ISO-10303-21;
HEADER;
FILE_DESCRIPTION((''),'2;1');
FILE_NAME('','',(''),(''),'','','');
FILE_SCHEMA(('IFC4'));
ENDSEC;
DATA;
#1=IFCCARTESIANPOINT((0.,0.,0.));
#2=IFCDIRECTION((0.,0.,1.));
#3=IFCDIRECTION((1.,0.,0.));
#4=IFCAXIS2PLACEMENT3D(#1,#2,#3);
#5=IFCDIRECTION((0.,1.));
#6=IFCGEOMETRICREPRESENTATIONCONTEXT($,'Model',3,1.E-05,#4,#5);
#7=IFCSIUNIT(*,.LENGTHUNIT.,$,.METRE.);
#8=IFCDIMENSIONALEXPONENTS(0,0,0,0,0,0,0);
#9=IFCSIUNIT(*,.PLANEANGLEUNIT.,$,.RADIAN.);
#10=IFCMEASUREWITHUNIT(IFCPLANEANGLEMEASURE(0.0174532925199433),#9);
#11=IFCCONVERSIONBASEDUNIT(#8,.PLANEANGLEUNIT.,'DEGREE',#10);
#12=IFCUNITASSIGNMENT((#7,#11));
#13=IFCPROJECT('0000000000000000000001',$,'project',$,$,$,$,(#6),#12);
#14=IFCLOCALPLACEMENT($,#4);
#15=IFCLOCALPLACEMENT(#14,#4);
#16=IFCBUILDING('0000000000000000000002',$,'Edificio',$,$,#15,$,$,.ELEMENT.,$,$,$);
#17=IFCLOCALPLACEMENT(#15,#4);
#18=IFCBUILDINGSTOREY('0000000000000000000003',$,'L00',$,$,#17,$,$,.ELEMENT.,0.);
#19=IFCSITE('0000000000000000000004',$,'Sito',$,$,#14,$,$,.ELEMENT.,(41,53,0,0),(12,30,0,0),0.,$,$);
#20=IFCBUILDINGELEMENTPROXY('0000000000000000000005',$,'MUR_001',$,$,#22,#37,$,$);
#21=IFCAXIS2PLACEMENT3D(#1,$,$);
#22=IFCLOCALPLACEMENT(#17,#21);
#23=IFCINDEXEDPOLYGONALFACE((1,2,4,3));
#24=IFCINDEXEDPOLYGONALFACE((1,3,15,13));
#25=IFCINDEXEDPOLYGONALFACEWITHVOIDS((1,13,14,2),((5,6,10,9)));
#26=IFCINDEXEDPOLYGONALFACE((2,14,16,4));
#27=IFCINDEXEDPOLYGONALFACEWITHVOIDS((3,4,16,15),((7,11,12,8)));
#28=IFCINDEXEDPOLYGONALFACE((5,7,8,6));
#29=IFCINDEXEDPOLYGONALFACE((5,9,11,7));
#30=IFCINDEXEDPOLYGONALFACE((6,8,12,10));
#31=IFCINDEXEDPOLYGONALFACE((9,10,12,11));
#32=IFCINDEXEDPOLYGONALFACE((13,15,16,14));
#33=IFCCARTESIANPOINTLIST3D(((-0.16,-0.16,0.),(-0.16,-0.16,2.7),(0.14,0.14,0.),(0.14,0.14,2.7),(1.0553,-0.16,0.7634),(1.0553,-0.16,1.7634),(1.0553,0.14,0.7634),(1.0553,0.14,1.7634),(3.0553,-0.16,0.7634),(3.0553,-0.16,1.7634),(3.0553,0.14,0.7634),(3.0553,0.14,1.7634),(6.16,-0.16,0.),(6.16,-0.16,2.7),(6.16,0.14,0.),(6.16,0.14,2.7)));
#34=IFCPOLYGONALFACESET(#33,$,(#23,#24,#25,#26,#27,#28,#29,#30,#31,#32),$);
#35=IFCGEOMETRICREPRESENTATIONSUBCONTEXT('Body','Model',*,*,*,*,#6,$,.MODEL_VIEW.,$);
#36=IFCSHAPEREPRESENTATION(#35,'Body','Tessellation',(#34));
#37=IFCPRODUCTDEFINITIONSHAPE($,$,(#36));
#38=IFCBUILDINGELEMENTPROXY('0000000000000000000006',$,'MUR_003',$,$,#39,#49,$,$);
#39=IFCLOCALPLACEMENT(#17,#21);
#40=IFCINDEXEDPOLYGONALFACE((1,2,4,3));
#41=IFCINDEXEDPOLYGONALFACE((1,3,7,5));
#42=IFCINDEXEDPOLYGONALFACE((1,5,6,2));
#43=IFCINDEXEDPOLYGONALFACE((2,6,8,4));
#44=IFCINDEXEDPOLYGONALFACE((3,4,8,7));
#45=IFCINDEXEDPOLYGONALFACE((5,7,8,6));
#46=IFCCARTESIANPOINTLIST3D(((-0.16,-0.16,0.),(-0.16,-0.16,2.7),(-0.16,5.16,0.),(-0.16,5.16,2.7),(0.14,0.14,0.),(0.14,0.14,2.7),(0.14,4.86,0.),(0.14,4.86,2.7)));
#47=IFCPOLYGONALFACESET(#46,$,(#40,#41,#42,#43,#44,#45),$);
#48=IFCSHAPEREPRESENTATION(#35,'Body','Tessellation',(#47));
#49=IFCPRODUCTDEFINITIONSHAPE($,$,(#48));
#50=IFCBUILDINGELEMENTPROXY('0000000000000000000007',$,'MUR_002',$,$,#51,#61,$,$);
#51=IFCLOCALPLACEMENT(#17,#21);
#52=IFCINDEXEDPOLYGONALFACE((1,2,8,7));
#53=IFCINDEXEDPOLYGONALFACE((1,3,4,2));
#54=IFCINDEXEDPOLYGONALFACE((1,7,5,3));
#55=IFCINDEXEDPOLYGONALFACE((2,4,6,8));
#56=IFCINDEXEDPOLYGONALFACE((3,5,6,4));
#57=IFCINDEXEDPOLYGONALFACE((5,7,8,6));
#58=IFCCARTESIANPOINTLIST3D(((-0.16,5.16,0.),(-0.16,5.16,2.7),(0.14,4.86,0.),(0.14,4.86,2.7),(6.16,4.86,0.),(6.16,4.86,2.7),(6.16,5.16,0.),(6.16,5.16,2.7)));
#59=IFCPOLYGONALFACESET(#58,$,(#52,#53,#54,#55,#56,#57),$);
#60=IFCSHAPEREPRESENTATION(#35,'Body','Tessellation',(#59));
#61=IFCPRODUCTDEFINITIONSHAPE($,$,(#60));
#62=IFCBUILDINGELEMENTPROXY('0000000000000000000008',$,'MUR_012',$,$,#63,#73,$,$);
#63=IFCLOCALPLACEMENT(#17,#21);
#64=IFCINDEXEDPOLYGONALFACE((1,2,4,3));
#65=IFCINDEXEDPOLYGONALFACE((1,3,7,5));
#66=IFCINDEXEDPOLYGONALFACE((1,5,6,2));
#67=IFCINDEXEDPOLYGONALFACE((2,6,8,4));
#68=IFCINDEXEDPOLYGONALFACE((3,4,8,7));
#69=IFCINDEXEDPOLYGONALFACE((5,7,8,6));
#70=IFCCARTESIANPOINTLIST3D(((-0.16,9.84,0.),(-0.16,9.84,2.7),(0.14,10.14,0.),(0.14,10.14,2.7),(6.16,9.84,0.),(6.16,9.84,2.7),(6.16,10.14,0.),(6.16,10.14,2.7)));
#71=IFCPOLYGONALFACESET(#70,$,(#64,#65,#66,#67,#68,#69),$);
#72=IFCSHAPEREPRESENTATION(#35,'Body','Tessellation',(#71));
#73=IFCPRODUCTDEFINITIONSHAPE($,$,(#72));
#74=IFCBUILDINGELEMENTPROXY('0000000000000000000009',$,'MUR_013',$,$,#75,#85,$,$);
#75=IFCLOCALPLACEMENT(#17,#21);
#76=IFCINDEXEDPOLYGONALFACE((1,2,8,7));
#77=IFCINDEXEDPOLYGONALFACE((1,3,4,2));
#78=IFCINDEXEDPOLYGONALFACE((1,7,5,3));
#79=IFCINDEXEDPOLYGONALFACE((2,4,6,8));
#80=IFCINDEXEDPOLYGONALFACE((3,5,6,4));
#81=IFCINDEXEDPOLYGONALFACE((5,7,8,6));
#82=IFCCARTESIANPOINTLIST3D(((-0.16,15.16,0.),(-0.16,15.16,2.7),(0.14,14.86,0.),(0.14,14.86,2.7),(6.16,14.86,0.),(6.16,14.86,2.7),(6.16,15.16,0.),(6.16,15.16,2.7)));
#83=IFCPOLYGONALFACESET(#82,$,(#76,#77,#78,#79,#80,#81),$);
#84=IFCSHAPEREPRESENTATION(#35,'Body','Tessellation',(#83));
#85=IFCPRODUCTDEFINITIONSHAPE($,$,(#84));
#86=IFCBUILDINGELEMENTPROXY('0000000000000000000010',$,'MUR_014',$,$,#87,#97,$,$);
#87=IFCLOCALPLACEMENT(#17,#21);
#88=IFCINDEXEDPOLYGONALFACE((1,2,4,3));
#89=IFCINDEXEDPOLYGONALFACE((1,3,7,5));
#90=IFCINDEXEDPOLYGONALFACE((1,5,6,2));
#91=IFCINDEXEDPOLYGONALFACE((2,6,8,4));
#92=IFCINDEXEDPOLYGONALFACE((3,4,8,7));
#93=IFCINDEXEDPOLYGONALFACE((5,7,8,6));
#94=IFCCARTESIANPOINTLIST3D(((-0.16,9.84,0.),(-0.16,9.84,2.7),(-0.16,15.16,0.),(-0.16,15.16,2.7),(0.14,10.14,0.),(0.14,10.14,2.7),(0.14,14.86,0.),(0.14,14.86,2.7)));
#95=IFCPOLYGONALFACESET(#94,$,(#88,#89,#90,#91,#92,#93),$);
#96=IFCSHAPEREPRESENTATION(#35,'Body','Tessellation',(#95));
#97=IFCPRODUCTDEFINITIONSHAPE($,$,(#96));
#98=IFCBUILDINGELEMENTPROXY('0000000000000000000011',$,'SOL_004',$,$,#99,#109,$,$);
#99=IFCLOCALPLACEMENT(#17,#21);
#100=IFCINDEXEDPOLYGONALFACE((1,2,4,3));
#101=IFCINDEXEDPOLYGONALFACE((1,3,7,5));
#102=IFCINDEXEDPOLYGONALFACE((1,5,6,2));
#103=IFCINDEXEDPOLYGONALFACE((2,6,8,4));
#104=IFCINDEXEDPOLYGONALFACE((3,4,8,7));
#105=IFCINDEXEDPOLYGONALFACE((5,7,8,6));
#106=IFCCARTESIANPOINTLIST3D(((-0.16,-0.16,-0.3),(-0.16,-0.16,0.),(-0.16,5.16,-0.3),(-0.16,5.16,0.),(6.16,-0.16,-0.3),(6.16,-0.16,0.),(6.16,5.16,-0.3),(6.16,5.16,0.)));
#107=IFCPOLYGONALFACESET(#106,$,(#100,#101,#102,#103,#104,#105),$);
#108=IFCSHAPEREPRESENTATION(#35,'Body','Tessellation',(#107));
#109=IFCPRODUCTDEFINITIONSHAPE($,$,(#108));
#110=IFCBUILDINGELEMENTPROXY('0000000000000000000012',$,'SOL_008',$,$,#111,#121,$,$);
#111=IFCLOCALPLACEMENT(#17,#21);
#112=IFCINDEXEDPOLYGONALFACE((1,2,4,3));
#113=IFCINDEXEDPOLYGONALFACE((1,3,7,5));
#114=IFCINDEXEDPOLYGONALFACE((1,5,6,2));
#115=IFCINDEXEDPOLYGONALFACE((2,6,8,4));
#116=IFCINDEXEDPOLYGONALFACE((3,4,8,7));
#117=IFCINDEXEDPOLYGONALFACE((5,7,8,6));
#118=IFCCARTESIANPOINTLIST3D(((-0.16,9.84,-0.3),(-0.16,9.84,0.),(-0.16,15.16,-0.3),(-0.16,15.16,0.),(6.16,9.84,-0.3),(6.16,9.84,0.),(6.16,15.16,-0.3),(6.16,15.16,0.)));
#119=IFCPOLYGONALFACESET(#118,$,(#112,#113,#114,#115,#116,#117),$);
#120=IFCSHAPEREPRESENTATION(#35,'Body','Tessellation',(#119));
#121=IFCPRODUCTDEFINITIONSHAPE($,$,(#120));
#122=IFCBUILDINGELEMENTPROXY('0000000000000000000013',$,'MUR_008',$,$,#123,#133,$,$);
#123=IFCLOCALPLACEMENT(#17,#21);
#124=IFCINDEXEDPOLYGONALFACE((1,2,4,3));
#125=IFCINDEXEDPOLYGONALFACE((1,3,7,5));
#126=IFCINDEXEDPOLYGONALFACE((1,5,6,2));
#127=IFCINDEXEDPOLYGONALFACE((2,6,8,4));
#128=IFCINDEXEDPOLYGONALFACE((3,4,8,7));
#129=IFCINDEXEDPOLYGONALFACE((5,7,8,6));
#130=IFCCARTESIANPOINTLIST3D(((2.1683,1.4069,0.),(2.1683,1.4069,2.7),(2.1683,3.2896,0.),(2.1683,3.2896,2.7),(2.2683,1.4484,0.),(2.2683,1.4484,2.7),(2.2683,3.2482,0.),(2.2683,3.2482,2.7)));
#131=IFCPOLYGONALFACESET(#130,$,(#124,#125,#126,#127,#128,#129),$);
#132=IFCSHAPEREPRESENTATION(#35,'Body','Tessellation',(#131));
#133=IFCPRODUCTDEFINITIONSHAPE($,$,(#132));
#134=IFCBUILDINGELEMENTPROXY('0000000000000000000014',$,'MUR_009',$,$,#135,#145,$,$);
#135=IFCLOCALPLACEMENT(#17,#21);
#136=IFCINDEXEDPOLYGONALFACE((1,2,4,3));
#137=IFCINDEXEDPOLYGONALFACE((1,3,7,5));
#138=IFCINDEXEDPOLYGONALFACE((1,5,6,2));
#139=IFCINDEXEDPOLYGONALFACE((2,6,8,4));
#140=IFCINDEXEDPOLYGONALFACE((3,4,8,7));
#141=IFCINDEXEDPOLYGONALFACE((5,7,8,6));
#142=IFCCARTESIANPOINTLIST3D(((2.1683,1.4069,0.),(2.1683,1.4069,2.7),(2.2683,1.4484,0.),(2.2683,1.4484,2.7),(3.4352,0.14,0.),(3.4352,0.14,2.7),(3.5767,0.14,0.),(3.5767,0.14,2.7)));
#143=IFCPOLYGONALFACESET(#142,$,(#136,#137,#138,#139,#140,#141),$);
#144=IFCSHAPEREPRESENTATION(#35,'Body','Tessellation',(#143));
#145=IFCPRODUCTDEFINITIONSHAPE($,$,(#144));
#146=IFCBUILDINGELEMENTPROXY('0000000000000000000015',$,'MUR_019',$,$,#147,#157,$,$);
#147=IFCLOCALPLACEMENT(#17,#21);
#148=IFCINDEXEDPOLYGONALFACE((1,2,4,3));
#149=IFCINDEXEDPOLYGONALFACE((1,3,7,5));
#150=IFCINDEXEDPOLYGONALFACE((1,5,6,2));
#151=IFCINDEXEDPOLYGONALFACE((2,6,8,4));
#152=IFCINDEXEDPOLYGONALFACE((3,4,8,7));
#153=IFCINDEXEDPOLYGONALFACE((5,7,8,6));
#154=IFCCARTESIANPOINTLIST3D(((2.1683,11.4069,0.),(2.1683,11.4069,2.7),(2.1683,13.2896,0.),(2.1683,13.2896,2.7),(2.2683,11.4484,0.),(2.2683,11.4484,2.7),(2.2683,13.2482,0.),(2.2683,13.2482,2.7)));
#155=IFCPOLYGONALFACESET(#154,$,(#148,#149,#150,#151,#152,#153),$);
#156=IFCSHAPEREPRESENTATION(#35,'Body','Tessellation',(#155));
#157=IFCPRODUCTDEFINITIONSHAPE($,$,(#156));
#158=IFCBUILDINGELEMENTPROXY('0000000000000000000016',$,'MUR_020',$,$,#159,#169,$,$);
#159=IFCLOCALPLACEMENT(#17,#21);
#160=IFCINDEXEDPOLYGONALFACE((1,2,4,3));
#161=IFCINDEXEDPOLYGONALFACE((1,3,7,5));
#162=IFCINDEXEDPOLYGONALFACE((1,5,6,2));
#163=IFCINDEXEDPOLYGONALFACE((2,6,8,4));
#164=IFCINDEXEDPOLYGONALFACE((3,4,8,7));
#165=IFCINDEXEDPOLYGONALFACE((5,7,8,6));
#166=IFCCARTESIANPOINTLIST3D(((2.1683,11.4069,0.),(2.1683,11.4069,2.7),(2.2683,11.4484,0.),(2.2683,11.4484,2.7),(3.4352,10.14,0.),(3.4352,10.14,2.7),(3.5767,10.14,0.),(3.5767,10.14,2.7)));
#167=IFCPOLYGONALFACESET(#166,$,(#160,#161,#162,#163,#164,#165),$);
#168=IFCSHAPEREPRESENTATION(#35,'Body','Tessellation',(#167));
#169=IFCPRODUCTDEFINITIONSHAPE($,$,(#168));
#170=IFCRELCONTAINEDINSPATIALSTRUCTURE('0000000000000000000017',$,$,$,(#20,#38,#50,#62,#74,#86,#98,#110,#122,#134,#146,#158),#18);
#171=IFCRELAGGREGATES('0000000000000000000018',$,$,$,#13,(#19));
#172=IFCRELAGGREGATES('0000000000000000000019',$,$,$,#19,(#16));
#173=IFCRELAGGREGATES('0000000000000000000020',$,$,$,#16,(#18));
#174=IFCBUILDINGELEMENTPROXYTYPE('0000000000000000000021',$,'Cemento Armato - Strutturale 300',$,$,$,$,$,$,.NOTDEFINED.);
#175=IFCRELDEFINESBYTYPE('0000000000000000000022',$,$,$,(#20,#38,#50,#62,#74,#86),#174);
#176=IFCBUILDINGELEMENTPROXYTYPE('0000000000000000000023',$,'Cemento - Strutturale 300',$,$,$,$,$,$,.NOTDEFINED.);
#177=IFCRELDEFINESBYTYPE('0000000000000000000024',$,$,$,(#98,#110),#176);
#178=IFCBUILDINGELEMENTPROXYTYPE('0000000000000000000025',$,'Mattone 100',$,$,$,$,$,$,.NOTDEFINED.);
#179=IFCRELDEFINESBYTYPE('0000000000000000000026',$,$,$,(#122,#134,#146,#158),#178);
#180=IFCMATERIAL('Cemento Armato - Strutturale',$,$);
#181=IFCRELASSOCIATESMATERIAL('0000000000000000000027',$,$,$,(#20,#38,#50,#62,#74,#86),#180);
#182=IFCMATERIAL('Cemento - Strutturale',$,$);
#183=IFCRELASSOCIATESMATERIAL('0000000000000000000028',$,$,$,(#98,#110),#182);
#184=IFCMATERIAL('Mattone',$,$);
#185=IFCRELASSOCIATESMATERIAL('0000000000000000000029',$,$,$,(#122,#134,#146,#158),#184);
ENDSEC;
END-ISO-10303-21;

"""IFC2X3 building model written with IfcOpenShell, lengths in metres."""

from ifc_helpers import new_model, entity, si_unit, converted_unit, direction, frame, origin_with_axes, origin_2d_with_axis, place, context, subcontext, project, spatial, polyline, rectangle, outline, extrude, material, type_object, element, save


model = new_model("IFC2X3")

# Units and contexts
model_context = context("Model", 3, precision=1e-05, world=origin_with_axes(), true_north=direction((0.0, 1.0)))
body_context = subcontext(model_context, "Body", "Model", "MODEL_VIEW")
ifc_project = project(units=[si_unit("LENGTHUNIT", "METRE"), converted_unit("PLANEANGLEUNIT", "DEGREE", entity("IfcPlaneAngleMeasure", 0.0174532925199433), si_unit("PLANEANGLEUNIT", "RADIAN"), dimensions=[0, 0, 0, 0, 0, 0, 0])], contexts=[model_context])

# Site, building, storey
site_placement = place(None, origin_with_axes())
site = spatial("IfcSite", under=ifc_project, at=site_placement, Name="Sito", CompositionType="ELEMENT", RefLatitude=(41, 53, 0, 0), RefLongitude=(12, 30, 0, 0), RefElevation=0.0)
building_placement = place(site_placement, origin_with_axes())
building = spatial("IfcBuilding", under=site, at=building_placement, Name="Edificio", CompositionType="ELEMENT")
storey_placement = place(building_placement, origin_with_axes())
storey = spatial("IfcBuildingStorey", under=building, at=storey_placement, Name="L00", CompositionType="ELEMENT", Elevation=0.0)

# Building element proxy, opening
ifc_material_1 = material(Name="Cemento Armato - Strutturale")
building_element_proxy_type_1 = type_object("IfcBuildingElementProxyType", Name="Cemento Armato - Strutturale 300", PredefinedType="NOTDEFINED")
proxy_1_placement = place(storey_placement, frame((-0.16, -0.16, 0.0), z_axis=(0.0, 0.0, 1.0), x_axis=(1.0, 0.0, 0.0)))
proxy_1 = element("IfcBuildingElementProxy", 1, at=proxy_1_placement, inside=storey, type_object=building_element_proxy_type_1, material=ifc_material_1, Name="MUR_001", context=body_context, shape_type="SweptSolid", body=[
    extrude(outline(polyline([(0.0, 0.0), (6.32, 0.0), (6.32, 0.3), (0.3, 0.3), (0.0, 0.0)])), origin_with_axes(), (0.0, 0.0, 1.0), 2.7),
])
opening_placement = place(proxy_1_placement, frame((0.16, 0.16, 0.0), z_axis=(0.0, 0.0, 1.0), x_axis=(1.0, 0.0, 0.0)))
element("IfcOpeningElement", 2, at=opening_placement, cuts=proxy_1, ObjectType="Empty Opening", context=body_context, shape_type="SweptSolid", body=[
    extrude(rectangle(XDim=2.0, YDim=1.0, at=origin_2d_with_axis()), frame((2.0553, -0.46, 1.2634), z_axis=(0.0, -1.0, 0.0), x_axis=(1.0, 0.0, 0.0)), (0.0, 0.0, -1.0), 0.9),
])

# Building element proxies
proxy_2_placement = place(storey_placement, frame((-0.16, 5.16, 0.0), z_axis=(0.0, 0.0, 1.0), x_axis=(0.0, -1.0, 0.0)))
element("IfcBuildingElementProxy", 3, at=proxy_2_placement, inside=storey, type_object=building_element_proxy_type_1, material=ifc_material_1, Name="MUR_003", context=body_context, shape_type="SweptSolid", body=[
    extrude(outline(polyline([(0.0, 0.0), (5.32, 0.0), (5.02, 0.3), (0.3, 0.3), (0.0, 0.0)])), origin_with_axes(), (0.0, 0.0, 1.0), 2.7),
])
proxy_3_placement = place(storey_placement, frame((6.16, 5.16, 0.0), z_axis=(0.0, 0.0, 1.0), x_axis=(-1.0, 0.0, 0.0)))
element("IfcBuildingElementProxy", 4, at=proxy_3_placement, inside=storey, type_object=building_element_proxy_type_1, material=ifc_material_1, Name="MUR_002", context=body_context, shape_type="SweptSolid", body=[
    extrude(outline(polyline([(0.0, 0.0), (6.32, 0.0), (6.02, 0.3), (0.0, 0.3), (0.0, 0.0)])), origin_with_axes(), (0.0, 0.0, 1.0), 2.7),
])
proxy_4_placement = place(storey_placement, frame((-0.16, 9.84, 0.0), z_axis=(0.0, 0.0, 1.0), x_axis=(1.0, 0.0, 0.0)))
element("IfcBuildingElementProxy", 5, at=proxy_4_placement, inside=storey, type_object=building_element_proxy_type_1, material=ifc_material_1, Name="MUR_012", context=body_context, shape_type="SweptSolid", body=[
    extrude(outline(polyline([(0.0, 0.0), (6.32, 0.0), (6.32, 0.3), (0.3, 0.3), (0.0, 0.0)])), origin_with_axes(), (0.0, 0.0, 1.0), 2.7),
])
proxy_5_placement = place(storey_placement, frame((6.16, 15.16, 0.0), z_axis=(0.0, 0.0, 1.0), x_axis=(-1.0, 0.0, 0.0)))
element("IfcBuildingElementProxy", 6, at=proxy_5_placement, inside=storey, type_object=building_element_proxy_type_1, material=ifc_material_1, Name="MUR_013", context=body_context, shape_type="SweptSolid", body=[
    extrude(outline(polyline([(0.0, 0.0), (6.32, 0.0), (6.02, 0.3), (0.0, 0.3), (0.0, 0.0)])), origin_with_axes(), (0.0, 0.0, 1.0), 2.7),
])
proxy_6_placement = place(storey_placement, frame((-0.16, 15.16, 0.0), z_axis=(0.0, 0.0, 1.0), x_axis=(0.0, -1.0, 0.0)))
element("IfcBuildingElementProxy", 7, at=proxy_6_placement, inside=storey, type_object=building_element_proxy_type_1, material=ifc_material_1, Name="MUR_014", context=body_context, shape_type="SweptSolid", body=[
    extrude(outline(polyline([(0.0, 0.0), (5.32, 0.0), (5.02, 0.3), (0.3, 0.3), (0.0, 0.0)])), origin_with_axes(), (0.0, 0.0, 1.0), 2.7),
])
ifc_material_2 = material(Name="Cemento - Strutturale")
building_element_proxy_type_2 = type_object("IfcBuildingElementProxyType", Name="Cemento - Strutturale 300", PredefinedType="NOTDEFINED")
for number, where, z_axis, x_axis, name in (
    (8, (-0.16, -0.16, 0.0), (0.0, 0.0, 1.0), (1.0, 0.0, 0.0), "SOL_004"),
    (9, (-0.16, 9.84, 0.0), (0.0, 0.0, 1.0), (1.0, 0.0, 0.0), "SOL_008"),
):
    element("IfcBuildingElementProxy", number, at=place(storey_placement, frame(where, z_axis=z_axis, x_axis=x_axis)), inside=storey, type_object=building_element_proxy_type_2, material=ifc_material_2, Name=name, context=body_context, shape_type="SweptSolid", body=[
        extrude(outline(polyline([(0.0, 0.0), (6.32, 0.0), (6.32, 5.32), (0.0, 5.32), (0.0, 0.0)])), frame((0.0, 0.0, -0.3), z_axis=(0.0, 0.0, 1.0), x_axis=(1.0, 0.0, 0.0)), (0.0, 0.0, 1.0), 0.3),
    ])
ifc_material_3 = material(Name="Mattone")
building_element_proxy_type_3 = type_object("IfcBuildingElementProxyType", Name="Mattone 100", PredefinedType="NOTDEFINED")
proxy_7_placement = place(storey_placement, frame((2.1683, 3.2896, 0.0), z_axis=(0.0, 0.0, 1.0), x_axis=(0.0, -1.0, 0.0)))
element("IfcBuildingElementProxy", 10, at=proxy_7_placement, inside=storey, type_object=building_element_proxy_type_3, material=ifc_material_3, Name="MUR_008", context=body_context, shape_type="SweptSolid", body=[
    extrude(outline(polyline([(0.0, 0.0), (1.8827, 0.0), (1.8412, 0.1), (0.0414, 0.1), (0.0, 0.0)])), origin_with_axes(), (0.0, 0.0, 1.0), 2.7),
])
proxy_8_placement = place(storey_placement, frame((2.1683, 1.4069, 0.0), z_axis=(0.0, 0.0, 1.0), x_axis=(0.707107, -0.707107, 0.0)))
element("IfcBuildingElementProxy", 11, at=proxy_8_placement, inside=storey, type_object=building_element_proxy_type_3, material=ifc_material_3, Name="MUR_009", context=body_context, shape_type="SweptSolid", body=[
    extrude(outline(polyline([(0.0, 0.0), (1.7917, 0.0), (1.8917, 0.1), (0.0414, 0.1), (0.0, 0.0)])), origin_with_axes(), (0.0, 0.0, 1.0), 2.7),
])
proxy_9_placement = place(storey_placement, frame((2.1683, 13.2896, 0.0), z_axis=(0.0, 0.0, 1.0), x_axis=(0.0, -1.0, 0.0)))
element("IfcBuildingElementProxy", 12, at=proxy_9_placement, inside=storey, type_object=building_element_proxy_type_3, material=ifc_material_3, Name="MUR_019", context=body_context, shape_type="SweptSolid", body=[
    extrude(outline(polyline([(0.0, 0.0), (1.8827, 0.0), (1.8412, 0.1), (0.0414, 0.1), (0.0, 0.0)])), origin_with_axes(), (0.0, 0.0, 1.0), 2.7),
])
proxy_10_placement = place(storey_placement, frame((2.1683, 11.4069, 0.0), z_axis=(0.0, 0.0, 1.0), x_axis=(0.707107, -0.707107, 0.0)))
element("IfcBuildingElementProxy", 13, at=proxy_10_placement, inside=storey, type_object=building_element_proxy_type_3, material=ifc_material_3, Name="MUR_020", context=body_context, shape_type="SweptSolid", body=[
    extrude(outline(polyline([(0.0, 0.0), (1.7917, 0.0), (1.8917, 0.1), (0.0414, 0.1), (0.0, 0.0)])), origin_with_axes(), (0.0, 0.0, 1.0), 2.7),
])

save(model, "model.ifc")
